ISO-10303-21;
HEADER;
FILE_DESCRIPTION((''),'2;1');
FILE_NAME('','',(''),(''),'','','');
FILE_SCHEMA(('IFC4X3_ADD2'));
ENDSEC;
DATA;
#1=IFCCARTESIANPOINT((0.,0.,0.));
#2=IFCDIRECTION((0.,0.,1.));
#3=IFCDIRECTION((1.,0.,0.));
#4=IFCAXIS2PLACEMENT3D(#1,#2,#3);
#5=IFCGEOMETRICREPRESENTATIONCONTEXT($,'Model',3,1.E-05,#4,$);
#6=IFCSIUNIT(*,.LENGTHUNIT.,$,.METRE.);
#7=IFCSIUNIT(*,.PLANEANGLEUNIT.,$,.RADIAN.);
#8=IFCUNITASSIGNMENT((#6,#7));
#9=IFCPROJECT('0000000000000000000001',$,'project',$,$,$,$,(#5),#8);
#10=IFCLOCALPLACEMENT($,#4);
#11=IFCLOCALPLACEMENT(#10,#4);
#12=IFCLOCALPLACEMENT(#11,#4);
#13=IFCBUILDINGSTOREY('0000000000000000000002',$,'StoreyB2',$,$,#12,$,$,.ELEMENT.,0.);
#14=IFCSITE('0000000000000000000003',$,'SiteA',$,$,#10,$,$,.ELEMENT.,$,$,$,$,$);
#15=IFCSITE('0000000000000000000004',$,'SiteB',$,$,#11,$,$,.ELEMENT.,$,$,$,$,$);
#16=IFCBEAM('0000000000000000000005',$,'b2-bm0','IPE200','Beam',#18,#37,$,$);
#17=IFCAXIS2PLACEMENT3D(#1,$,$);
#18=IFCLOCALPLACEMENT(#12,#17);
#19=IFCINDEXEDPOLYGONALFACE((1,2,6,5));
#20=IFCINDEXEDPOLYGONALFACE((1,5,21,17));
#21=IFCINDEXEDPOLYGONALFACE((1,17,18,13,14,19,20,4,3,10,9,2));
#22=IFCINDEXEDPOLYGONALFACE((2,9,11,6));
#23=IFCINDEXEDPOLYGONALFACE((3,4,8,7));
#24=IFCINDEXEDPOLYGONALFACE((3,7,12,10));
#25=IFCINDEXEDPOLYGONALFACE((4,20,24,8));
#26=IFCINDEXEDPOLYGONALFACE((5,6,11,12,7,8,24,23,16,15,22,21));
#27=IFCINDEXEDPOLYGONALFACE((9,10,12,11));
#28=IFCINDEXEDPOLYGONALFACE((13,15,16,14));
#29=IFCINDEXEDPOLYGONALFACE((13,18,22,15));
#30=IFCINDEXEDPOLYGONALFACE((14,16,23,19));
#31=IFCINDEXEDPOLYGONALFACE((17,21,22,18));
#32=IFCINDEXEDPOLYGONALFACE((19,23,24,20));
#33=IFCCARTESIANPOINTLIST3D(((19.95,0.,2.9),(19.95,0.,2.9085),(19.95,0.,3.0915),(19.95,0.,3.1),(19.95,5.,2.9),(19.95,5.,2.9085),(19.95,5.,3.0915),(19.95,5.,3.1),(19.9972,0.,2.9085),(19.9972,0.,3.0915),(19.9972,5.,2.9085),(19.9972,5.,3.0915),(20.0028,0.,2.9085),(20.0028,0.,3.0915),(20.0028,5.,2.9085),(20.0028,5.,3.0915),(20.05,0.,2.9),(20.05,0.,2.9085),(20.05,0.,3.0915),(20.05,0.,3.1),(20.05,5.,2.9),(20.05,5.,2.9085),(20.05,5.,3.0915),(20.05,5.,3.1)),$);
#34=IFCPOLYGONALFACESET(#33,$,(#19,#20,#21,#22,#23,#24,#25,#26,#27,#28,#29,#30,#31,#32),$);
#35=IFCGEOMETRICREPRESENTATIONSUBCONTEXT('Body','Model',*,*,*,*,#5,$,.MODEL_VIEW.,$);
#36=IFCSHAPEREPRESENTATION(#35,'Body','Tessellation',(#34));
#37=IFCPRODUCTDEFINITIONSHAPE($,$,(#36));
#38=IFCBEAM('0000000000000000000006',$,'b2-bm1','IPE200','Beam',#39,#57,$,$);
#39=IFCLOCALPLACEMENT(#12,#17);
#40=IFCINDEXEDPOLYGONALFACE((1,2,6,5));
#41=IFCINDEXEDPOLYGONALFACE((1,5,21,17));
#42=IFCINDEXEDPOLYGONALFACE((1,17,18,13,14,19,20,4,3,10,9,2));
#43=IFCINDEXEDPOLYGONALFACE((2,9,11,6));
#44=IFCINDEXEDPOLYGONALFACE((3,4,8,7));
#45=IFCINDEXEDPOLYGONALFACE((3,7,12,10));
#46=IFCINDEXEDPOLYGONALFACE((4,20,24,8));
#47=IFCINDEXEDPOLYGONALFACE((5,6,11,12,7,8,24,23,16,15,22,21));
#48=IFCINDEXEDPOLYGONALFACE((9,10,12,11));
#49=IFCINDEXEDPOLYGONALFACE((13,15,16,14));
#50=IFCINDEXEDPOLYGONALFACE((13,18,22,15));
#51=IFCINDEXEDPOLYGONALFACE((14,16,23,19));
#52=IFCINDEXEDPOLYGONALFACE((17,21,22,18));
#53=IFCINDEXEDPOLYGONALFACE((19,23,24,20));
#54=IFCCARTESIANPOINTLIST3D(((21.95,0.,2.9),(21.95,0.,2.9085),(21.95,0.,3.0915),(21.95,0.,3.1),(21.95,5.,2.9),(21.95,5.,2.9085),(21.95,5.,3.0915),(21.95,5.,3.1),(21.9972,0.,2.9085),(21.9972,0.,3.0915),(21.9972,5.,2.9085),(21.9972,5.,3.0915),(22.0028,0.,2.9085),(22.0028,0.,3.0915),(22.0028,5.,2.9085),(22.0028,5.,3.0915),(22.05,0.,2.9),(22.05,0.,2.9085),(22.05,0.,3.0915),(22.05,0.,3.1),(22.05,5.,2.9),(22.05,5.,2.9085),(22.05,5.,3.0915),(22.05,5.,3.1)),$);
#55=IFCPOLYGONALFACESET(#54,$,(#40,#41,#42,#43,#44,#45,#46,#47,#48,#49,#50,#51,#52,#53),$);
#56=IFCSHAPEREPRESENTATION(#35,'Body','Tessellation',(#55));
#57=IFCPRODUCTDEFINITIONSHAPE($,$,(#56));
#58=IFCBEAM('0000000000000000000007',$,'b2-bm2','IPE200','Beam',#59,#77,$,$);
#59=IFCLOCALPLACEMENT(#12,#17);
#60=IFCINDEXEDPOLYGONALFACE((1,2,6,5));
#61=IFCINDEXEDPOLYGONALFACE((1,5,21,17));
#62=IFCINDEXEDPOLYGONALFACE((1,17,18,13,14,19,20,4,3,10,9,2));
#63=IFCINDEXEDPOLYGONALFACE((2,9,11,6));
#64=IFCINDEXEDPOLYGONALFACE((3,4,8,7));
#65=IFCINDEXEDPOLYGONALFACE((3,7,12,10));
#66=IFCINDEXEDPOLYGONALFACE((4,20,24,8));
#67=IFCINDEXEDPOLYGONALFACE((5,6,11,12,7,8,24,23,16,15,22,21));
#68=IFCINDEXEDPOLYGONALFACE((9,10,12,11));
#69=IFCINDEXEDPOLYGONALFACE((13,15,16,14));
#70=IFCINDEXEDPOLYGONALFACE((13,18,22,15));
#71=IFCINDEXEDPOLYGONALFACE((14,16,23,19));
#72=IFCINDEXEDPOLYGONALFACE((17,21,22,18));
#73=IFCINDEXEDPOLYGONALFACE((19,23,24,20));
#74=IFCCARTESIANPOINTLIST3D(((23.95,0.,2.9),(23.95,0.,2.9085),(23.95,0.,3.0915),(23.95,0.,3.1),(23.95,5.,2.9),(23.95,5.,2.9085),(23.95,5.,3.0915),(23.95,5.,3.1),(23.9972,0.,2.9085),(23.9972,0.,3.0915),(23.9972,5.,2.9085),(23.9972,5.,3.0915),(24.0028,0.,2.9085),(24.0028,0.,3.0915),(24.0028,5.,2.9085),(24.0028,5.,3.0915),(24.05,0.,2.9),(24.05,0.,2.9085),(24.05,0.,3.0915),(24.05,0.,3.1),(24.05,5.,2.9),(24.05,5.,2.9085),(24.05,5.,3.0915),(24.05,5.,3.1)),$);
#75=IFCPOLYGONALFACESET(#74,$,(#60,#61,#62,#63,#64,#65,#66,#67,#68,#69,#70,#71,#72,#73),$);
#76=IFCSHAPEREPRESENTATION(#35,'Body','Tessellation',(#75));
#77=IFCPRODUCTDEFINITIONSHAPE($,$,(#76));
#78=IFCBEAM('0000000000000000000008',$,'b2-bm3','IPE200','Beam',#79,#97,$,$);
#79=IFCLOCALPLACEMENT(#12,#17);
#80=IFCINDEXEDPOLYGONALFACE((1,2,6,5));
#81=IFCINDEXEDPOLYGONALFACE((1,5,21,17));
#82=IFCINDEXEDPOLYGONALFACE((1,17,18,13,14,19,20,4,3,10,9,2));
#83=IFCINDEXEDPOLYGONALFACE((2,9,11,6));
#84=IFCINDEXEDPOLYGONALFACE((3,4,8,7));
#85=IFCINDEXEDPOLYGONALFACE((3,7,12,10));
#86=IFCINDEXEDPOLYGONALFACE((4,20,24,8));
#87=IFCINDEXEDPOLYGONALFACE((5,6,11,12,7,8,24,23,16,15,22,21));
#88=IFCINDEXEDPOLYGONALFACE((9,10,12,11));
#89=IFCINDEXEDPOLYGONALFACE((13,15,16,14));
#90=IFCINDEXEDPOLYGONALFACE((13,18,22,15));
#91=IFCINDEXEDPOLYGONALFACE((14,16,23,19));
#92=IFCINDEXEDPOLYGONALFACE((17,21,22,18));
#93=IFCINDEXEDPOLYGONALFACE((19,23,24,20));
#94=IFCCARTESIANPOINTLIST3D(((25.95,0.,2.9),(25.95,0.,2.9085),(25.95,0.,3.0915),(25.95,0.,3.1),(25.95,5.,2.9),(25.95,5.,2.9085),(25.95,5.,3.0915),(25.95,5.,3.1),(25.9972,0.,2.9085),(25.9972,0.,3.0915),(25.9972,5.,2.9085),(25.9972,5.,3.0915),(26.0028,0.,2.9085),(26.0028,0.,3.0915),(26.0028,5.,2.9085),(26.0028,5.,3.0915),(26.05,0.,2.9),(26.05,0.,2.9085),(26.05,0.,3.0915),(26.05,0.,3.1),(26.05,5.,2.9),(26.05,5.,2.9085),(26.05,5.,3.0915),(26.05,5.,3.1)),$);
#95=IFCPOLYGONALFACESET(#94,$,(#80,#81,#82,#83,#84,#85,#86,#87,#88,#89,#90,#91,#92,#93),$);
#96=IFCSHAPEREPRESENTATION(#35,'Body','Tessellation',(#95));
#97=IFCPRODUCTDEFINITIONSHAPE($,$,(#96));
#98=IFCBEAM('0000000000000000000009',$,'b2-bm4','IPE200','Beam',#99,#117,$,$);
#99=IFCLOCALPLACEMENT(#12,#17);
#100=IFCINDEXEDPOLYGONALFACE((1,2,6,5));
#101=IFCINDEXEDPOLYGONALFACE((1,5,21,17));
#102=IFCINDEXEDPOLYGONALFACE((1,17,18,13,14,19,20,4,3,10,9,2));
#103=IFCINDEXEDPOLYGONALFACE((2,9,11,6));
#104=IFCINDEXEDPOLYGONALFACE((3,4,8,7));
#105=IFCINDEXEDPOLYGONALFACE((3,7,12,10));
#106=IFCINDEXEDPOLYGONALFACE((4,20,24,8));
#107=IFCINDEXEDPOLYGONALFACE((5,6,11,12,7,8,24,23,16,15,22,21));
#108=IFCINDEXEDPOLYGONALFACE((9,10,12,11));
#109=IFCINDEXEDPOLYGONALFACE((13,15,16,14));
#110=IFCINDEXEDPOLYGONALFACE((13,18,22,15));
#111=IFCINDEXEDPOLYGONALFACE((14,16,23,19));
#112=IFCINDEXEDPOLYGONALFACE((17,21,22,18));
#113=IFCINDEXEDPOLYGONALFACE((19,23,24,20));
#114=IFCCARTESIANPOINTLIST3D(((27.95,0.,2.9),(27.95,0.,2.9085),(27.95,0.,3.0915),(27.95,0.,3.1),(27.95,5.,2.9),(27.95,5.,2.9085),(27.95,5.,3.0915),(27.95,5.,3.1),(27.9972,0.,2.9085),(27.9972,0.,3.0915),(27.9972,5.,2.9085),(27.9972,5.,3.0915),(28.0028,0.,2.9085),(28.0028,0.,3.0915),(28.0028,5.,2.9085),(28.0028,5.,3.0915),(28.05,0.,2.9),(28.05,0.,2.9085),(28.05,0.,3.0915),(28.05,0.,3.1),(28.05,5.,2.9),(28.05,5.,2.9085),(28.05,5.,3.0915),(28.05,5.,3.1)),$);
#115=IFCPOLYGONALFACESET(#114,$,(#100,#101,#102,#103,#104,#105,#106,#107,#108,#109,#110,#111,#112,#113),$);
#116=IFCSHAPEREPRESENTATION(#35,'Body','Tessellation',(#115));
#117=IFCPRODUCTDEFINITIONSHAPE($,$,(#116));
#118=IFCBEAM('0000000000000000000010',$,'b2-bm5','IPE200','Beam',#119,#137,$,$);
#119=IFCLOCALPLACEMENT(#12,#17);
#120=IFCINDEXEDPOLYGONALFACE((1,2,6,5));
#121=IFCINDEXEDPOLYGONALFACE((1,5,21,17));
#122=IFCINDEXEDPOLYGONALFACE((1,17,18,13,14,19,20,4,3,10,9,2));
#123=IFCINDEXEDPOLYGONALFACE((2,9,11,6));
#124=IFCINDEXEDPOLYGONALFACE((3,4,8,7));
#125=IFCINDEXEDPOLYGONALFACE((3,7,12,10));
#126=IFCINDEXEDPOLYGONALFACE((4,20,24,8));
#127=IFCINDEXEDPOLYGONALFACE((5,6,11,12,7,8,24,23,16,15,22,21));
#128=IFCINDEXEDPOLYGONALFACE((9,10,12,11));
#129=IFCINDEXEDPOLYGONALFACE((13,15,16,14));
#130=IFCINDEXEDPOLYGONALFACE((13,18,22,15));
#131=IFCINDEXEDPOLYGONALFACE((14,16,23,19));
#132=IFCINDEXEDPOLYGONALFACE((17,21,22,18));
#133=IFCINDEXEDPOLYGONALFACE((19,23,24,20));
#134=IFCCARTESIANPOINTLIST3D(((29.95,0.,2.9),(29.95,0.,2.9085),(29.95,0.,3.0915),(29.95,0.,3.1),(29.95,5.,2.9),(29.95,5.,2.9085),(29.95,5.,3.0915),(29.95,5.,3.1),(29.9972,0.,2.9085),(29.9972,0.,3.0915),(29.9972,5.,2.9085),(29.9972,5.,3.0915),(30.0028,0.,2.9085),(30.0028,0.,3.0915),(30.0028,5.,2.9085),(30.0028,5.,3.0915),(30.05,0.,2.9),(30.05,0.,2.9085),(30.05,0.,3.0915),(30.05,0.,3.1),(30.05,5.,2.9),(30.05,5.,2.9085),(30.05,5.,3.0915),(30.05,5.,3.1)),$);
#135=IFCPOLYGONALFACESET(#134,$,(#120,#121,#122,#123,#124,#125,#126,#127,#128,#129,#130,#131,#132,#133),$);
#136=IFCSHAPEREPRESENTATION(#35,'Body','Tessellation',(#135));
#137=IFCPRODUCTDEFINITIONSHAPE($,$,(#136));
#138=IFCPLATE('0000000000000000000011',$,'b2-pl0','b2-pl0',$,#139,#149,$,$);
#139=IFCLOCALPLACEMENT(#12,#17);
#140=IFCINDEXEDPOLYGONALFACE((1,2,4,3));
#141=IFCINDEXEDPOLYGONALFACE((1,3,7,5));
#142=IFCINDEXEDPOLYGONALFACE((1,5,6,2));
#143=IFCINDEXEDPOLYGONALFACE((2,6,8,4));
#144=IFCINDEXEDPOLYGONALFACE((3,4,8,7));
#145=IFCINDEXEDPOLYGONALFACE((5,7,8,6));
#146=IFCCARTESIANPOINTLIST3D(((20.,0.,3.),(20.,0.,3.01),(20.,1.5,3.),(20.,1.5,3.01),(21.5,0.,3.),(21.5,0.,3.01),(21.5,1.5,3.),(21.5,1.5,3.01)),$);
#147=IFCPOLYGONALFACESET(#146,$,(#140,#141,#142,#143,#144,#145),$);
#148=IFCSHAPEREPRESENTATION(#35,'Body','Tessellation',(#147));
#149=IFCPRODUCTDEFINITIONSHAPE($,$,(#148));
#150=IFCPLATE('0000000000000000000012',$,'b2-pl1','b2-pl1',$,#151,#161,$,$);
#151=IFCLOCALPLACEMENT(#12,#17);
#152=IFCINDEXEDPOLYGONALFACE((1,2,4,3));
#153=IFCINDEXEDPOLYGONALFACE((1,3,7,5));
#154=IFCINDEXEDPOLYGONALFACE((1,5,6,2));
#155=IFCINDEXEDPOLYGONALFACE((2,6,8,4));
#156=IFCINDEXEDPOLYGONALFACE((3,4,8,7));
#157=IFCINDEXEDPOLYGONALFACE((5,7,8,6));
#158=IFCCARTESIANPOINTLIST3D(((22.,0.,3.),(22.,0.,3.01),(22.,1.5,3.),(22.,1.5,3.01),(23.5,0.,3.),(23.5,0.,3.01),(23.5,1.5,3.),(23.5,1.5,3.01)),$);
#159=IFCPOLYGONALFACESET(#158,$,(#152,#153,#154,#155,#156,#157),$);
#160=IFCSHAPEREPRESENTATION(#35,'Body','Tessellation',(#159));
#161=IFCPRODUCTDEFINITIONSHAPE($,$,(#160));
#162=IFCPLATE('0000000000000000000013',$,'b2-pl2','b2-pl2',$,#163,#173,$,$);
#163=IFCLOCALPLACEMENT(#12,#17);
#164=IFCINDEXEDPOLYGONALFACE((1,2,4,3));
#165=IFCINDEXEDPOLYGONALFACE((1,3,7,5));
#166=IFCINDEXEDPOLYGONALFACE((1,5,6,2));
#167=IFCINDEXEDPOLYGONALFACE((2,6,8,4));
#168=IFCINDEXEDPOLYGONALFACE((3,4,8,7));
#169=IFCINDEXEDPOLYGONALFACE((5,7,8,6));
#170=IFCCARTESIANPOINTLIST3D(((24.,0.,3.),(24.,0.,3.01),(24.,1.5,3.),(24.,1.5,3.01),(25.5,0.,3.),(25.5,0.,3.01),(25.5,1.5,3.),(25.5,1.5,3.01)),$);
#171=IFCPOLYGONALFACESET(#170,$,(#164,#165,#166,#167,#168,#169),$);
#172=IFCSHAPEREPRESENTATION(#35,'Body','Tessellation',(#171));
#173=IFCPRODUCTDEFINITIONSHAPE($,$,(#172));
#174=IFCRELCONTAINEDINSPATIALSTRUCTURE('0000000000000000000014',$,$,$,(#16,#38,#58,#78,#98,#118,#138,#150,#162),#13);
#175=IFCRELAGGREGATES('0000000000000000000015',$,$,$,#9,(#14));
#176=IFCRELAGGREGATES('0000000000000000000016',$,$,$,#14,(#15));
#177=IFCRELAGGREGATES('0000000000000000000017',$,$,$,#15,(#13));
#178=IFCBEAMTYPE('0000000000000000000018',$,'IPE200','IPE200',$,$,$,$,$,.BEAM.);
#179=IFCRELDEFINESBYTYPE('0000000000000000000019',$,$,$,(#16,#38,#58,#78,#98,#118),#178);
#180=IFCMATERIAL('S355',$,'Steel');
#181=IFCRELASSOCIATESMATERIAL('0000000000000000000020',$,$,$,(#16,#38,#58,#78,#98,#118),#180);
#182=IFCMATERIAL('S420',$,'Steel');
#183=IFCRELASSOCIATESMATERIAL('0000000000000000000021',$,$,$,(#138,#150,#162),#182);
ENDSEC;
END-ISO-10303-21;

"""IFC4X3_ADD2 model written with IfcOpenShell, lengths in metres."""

from ifc_helpers import new_model, si_unit, frame, origin_with_axes, place, context, subcontext, project, spatial, line, indexed_curve, i_section, outline, extrude, material, material_profile, profile_set, profile_usage, type_object, element, save


model = new_model("IFC4X3_ADD2")

# Units and contexts
model_context = context("Model", 3, precision=1e-05, world=origin_with_axes())
body_context = subcontext(model_context, "Body", "Model", "MODEL_VIEW")
ifc_project = project(units=[si_unit("LENGTHUNIT", "METRE"), si_unit("PLANEANGLEUNIT", "RADIAN")], contexts=[model_context])

# Sites, storey
site_1_placement = place(None, origin_with_axes())
site_1 = spatial("IfcSite", under=ifc_project, at=site_1_placement, Name="SiteA", CompositionType="ELEMENT")
site_2_placement = place(site_1_placement, origin_with_axes())
site_2 = spatial("IfcSite", under=site_1, at=site_2_placement, Name="SiteB", CompositionType="ELEMENT")
storey_placement = place(site_2_placement, origin_with_axes())
storey = spatial("IfcBuildingStorey", under=site_2, at=storey_placement, Name="StoreyB2", CompositionType="ELEMENT", Elevation=0.0)

# Beams
ifc_material_1 = material(Name="S355", Category="Steel")
ifc_material_profile_1 = material_profile(ifc_material_1, i_section(OverallWidth=0.1, OverallDepth=0.2, WebThickness=0.0056, FlangeThickness=0.0085), Name="IPE200", Category="LoadBearing")
ifc_profile_set_1 = profile_set([ifc_material_profile_1], Name="IPE200")
ifc_profile_usage_1 = profile_usage(ifc_profile_set_1, cardinal=5)
beam_type = type_object("IfcBeamType", Name="IPE200", Description="IPE200", PredefinedType="BEAM")
placement_1 = place(storey_placement, origin_with_axes())
beam_1_placement = place(placement_1, origin_with_axes())
element("IfcBeam", 1, at=beam_1_placement, inside=storey, type_object=beam_type, material=ifc_profile_usage_1, Name="b2-bm0", Description="IPE200", ObjectType="Beam", context=body_context, shape_type="SolidModel", body=[
    extrude(i_section(OverallWidth=0.1, OverallDepth=0.2, WebThickness=0.0056, FlangeThickness=0.0085), frame((20.0, 0.0, 3.0), z_axis=(0.0, 1.0, 0.0), x_axis=(-1.0, 0.0, 0.0)), (0.0, 0.0, 1.0), 5.0),
])
ifc_material_profile_2 = material_profile(ifc_material_1, i_section(OverallWidth=0.1, OverallDepth=0.2, WebThickness=0.0056, FlangeThickness=0.0085), Name="IPE200", Category="LoadBearing")
ifc_profile_set_2 = profile_set([ifc_material_profile_2], Name="IPE200")
ifc_profile_usage_2 = profile_usage(ifc_profile_set_2, cardinal=5)
placement_2 = place(storey_placement, origin_with_axes())
beam_2_placement = place(placement_2, origin_with_axes())
element("IfcBeam", 2, at=beam_2_placement, inside=storey, type_object=beam_type, material=ifc_profile_usage_2, Name="b2-bm1", Description="IPE200", ObjectType="Beam", context=body_context, shape_type="SolidModel", body=[
    extrude(i_section(OverallWidth=0.1, OverallDepth=0.2, WebThickness=0.0056, FlangeThickness=0.0085), frame((22.0, 0.0, 3.0), z_axis=(0.0, 1.0, 0.0), x_axis=(-1.0, 0.0, 0.0)), (0.0, 0.0, 1.0), 5.0),
])
ifc_material_profile_3 = material_profile(ifc_material_1, i_section(OverallWidth=0.1, OverallDepth=0.2, WebThickness=0.0056, FlangeThickness=0.0085), Name="IPE200", Category="LoadBearing")
ifc_profile_set_3 = profile_set([ifc_material_profile_3], Name="IPE200")
ifc_profile_usage_3 = profile_usage(ifc_profile_set_3, cardinal=5)
placement_3 = place(storey_placement, origin_with_axes())
beam_3_placement = place(placement_3, origin_with_axes())
element("IfcBeam", 3, at=beam_3_placement, inside=storey, type_object=beam_type, material=ifc_profile_usage_3, Name="b2-bm2", Description="IPE200", ObjectType="Beam", context=body_context, shape_type="SolidModel", body=[
    extrude(i_section(OverallWidth=0.1, OverallDepth=0.2, WebThickness=0.0056, FlangeThickness=0.0085), frame((24.0, 0.0, 3.0), z_axis=(0.0, 1.0, 0.0), x_axis=(-1.0, 0.0, 0.0)), (0.0, 0.0, 1.0), 5.0),
])
ifc_material_profile_4 = material_profile(ifc_material_1, i_section(OverallWidth=0.1, OverallDepth=0.2, WebThickness=0.0056, FlangeThickness=0.0085), Name="IPE200", Category="LoadBearing")
ifc_profile_set_4 = profile_set([ifc_material_profile_4], Name="IPE200")
ifc_profile_usage_4 = profile_usage(ifc_profile_set_4, cardinal=5)
placement_4 = place(storey_placement, origin_with_axes())
beam_4_placement = place(placement_4, origin_with_axes())
element("IfcBeam", 4, at=beam_4_placement, inside=storey, type_object=beam_type, material=ifc_profile_usage_4, Name="b2-bm3", Description="IPE200", ObjectType="Beam", context=body_context, shape_type="SolidModel", body=[
    extrude(i_section(OverallWidth=0.1, OverallDepth=0.2, WebThickness=0.0056, FlangeThickness=0.0085), frame((26.0, 0.0, 3.0), z_axis=(0.0, 1.0, 0.0), x_axis=(-1.0, 0.0, 0.0)), (0.0, 0.0, 1.0), 5.0),
])
ifc_material_profile_5 = material_profile(ifc_material_1, i_section(OverallWidth=0.1, OverallDepth=0.2, WebThickness=0.0056, FlangeThickness=0.0085), Name="IPE200", Category="LoadBearing")
ifc_profile_set_5 = profile_set([ifc_material_profile_5], Name="IPE200")
ifc_profile_usage_5 = profile_usage(ifc_profile_set_5, cardinal=5)
placement_5 = place(storey_placement, origin_with_axes())
beam_5_placement = place(placement_5, origin_with_axes())
element("IfcBeam", 5, at=beam_5_placement, inside=storey, type_object=beam_type, material=ifc_profile_usage_5, Name="b2-bm4", Description="IPE200", ObjectType="Beam", context=body_context, shape_type="SolidModel", body=[
    extrude(i_section(OverallWidth=0.1, OverallDepth=0.2, WebThickness=0.0056, FlangeThickness=0.0085), frame((28.0, 0.0, 3.0), z_axis=(0.0, 1.0, 0.0), x_axis=(-1.0, 0.0, 0.0)), (0.0, 0.0, 1.0), 5.0),
])
ifc_material_profile_6 = material_profile(ifc_material_1, i_section(OverallWidth=0.1, OverallDepth=0.2, WebThickness=0.0056, FlangeThickness=0.0085), Name="IPE200", Category="LoadBearing")
ifc_profile_set_6 = profile_set([ifc_material_profile_6], Name="IPE200")
ifc_profile_usage_6 = profile_usage(ifc_profile_set_6, cardinal=5)
placement_6 = place(storey_placement, origin_with_axes())
beam_6_placement = place(placement_6, origin_with_axes())
element("IfcBeam", 6, at=beam_6_placement, inside=storey, type_object=beam_type, material=ifc_profile_usage_6, Name="b2-bm5", Description="IPE200", ObjectType="Beam", context=body_context, shape_type="SolidModel", body=[
    extrude(i_section(OverallWidth=0.1, OverallDepth=0.2, WebThickness=0.0056, FlangeThickness=0.0085), frame((30.0, 0.0, 3.0), z_axis=(0.0, 1.0, 0.0), x_axis=(-1.0, 0.0, 0.0)), (0.0, 0.0, 1.0), 5.0),
])

# Plates
ifc_material_2 = material(Name="S420", Category="Steel")
plate_1_placement = place(None, origin_with_axes())
element("IfcPlate", 7, at=plate_1_placement, inside=storey, material=ifc_material_2, Name="b2-pl0", Description="b2-pl0", context=body_context, shape_type="SolidModel", body=[
    extrude(outline(indexed_curve([(20.0, 0.0), (20.0, 1.5), (21.5, 0.0), (21.5, 1.5)], segments=[line(3, 1), line(1, 2), line(2, 4), line(4, 3)])), frame((0.0, 0.0, 3.0), z_axis=(0.0, 0.0, 1.0), x_axis=(1.0, 0.0, 0.0)), (0.0, 0.0, 1.0), 0.01),
])
plate_2_placement = place(None, origin_with_axes())
element("IfcPlate", 8, at=plate_2_placement, inside=storey, material=ifc_material_2, Name="b2-pl1", Description="b2-pl1", context=body_context, shape_type="SolidModel", body=[
    extrude(outline(indexed_curve([(22.0, 0.0), (22.0, 1.5), (23.5, 0.0), (23.5, 1.5)], segments=[line(3, 1), line(1, 2), line(2, 4), line(4, 3)])), frame((0.0, 0.0, 3.0), z_axis=(0.0, 0.0, 1.0), x_axis=(1.0, 0.0, 0.0)), (0.0, 0.0, 1.0), 0.01),
])
plate_3_placement = place(None, origin_with_axes())
element("IfcPlate", 9, at=plate_3_placement, inside=storey, material=ifc_material_2, Name="b2-pl2", Description="b2-pl2", context=body_context, shape_type="SolidModel", body=[
    extrude(outline(indexed_curve([(24.0, 0.0), (24.0, 1.5), (25.5, 0.0), (25.5, 1.5)], segments=[line(3, 1), line(1, 2), line(2, 4), line(4, 3)])), frame((0.0, 0.0, 3.0), z_axis=(0.0, 0.0, 1.0), x_axis=(1.0, 0.0, 0.0)), (0.0, 0.0, 1.0), 0.01),
])

save(model, "model.ifc")
